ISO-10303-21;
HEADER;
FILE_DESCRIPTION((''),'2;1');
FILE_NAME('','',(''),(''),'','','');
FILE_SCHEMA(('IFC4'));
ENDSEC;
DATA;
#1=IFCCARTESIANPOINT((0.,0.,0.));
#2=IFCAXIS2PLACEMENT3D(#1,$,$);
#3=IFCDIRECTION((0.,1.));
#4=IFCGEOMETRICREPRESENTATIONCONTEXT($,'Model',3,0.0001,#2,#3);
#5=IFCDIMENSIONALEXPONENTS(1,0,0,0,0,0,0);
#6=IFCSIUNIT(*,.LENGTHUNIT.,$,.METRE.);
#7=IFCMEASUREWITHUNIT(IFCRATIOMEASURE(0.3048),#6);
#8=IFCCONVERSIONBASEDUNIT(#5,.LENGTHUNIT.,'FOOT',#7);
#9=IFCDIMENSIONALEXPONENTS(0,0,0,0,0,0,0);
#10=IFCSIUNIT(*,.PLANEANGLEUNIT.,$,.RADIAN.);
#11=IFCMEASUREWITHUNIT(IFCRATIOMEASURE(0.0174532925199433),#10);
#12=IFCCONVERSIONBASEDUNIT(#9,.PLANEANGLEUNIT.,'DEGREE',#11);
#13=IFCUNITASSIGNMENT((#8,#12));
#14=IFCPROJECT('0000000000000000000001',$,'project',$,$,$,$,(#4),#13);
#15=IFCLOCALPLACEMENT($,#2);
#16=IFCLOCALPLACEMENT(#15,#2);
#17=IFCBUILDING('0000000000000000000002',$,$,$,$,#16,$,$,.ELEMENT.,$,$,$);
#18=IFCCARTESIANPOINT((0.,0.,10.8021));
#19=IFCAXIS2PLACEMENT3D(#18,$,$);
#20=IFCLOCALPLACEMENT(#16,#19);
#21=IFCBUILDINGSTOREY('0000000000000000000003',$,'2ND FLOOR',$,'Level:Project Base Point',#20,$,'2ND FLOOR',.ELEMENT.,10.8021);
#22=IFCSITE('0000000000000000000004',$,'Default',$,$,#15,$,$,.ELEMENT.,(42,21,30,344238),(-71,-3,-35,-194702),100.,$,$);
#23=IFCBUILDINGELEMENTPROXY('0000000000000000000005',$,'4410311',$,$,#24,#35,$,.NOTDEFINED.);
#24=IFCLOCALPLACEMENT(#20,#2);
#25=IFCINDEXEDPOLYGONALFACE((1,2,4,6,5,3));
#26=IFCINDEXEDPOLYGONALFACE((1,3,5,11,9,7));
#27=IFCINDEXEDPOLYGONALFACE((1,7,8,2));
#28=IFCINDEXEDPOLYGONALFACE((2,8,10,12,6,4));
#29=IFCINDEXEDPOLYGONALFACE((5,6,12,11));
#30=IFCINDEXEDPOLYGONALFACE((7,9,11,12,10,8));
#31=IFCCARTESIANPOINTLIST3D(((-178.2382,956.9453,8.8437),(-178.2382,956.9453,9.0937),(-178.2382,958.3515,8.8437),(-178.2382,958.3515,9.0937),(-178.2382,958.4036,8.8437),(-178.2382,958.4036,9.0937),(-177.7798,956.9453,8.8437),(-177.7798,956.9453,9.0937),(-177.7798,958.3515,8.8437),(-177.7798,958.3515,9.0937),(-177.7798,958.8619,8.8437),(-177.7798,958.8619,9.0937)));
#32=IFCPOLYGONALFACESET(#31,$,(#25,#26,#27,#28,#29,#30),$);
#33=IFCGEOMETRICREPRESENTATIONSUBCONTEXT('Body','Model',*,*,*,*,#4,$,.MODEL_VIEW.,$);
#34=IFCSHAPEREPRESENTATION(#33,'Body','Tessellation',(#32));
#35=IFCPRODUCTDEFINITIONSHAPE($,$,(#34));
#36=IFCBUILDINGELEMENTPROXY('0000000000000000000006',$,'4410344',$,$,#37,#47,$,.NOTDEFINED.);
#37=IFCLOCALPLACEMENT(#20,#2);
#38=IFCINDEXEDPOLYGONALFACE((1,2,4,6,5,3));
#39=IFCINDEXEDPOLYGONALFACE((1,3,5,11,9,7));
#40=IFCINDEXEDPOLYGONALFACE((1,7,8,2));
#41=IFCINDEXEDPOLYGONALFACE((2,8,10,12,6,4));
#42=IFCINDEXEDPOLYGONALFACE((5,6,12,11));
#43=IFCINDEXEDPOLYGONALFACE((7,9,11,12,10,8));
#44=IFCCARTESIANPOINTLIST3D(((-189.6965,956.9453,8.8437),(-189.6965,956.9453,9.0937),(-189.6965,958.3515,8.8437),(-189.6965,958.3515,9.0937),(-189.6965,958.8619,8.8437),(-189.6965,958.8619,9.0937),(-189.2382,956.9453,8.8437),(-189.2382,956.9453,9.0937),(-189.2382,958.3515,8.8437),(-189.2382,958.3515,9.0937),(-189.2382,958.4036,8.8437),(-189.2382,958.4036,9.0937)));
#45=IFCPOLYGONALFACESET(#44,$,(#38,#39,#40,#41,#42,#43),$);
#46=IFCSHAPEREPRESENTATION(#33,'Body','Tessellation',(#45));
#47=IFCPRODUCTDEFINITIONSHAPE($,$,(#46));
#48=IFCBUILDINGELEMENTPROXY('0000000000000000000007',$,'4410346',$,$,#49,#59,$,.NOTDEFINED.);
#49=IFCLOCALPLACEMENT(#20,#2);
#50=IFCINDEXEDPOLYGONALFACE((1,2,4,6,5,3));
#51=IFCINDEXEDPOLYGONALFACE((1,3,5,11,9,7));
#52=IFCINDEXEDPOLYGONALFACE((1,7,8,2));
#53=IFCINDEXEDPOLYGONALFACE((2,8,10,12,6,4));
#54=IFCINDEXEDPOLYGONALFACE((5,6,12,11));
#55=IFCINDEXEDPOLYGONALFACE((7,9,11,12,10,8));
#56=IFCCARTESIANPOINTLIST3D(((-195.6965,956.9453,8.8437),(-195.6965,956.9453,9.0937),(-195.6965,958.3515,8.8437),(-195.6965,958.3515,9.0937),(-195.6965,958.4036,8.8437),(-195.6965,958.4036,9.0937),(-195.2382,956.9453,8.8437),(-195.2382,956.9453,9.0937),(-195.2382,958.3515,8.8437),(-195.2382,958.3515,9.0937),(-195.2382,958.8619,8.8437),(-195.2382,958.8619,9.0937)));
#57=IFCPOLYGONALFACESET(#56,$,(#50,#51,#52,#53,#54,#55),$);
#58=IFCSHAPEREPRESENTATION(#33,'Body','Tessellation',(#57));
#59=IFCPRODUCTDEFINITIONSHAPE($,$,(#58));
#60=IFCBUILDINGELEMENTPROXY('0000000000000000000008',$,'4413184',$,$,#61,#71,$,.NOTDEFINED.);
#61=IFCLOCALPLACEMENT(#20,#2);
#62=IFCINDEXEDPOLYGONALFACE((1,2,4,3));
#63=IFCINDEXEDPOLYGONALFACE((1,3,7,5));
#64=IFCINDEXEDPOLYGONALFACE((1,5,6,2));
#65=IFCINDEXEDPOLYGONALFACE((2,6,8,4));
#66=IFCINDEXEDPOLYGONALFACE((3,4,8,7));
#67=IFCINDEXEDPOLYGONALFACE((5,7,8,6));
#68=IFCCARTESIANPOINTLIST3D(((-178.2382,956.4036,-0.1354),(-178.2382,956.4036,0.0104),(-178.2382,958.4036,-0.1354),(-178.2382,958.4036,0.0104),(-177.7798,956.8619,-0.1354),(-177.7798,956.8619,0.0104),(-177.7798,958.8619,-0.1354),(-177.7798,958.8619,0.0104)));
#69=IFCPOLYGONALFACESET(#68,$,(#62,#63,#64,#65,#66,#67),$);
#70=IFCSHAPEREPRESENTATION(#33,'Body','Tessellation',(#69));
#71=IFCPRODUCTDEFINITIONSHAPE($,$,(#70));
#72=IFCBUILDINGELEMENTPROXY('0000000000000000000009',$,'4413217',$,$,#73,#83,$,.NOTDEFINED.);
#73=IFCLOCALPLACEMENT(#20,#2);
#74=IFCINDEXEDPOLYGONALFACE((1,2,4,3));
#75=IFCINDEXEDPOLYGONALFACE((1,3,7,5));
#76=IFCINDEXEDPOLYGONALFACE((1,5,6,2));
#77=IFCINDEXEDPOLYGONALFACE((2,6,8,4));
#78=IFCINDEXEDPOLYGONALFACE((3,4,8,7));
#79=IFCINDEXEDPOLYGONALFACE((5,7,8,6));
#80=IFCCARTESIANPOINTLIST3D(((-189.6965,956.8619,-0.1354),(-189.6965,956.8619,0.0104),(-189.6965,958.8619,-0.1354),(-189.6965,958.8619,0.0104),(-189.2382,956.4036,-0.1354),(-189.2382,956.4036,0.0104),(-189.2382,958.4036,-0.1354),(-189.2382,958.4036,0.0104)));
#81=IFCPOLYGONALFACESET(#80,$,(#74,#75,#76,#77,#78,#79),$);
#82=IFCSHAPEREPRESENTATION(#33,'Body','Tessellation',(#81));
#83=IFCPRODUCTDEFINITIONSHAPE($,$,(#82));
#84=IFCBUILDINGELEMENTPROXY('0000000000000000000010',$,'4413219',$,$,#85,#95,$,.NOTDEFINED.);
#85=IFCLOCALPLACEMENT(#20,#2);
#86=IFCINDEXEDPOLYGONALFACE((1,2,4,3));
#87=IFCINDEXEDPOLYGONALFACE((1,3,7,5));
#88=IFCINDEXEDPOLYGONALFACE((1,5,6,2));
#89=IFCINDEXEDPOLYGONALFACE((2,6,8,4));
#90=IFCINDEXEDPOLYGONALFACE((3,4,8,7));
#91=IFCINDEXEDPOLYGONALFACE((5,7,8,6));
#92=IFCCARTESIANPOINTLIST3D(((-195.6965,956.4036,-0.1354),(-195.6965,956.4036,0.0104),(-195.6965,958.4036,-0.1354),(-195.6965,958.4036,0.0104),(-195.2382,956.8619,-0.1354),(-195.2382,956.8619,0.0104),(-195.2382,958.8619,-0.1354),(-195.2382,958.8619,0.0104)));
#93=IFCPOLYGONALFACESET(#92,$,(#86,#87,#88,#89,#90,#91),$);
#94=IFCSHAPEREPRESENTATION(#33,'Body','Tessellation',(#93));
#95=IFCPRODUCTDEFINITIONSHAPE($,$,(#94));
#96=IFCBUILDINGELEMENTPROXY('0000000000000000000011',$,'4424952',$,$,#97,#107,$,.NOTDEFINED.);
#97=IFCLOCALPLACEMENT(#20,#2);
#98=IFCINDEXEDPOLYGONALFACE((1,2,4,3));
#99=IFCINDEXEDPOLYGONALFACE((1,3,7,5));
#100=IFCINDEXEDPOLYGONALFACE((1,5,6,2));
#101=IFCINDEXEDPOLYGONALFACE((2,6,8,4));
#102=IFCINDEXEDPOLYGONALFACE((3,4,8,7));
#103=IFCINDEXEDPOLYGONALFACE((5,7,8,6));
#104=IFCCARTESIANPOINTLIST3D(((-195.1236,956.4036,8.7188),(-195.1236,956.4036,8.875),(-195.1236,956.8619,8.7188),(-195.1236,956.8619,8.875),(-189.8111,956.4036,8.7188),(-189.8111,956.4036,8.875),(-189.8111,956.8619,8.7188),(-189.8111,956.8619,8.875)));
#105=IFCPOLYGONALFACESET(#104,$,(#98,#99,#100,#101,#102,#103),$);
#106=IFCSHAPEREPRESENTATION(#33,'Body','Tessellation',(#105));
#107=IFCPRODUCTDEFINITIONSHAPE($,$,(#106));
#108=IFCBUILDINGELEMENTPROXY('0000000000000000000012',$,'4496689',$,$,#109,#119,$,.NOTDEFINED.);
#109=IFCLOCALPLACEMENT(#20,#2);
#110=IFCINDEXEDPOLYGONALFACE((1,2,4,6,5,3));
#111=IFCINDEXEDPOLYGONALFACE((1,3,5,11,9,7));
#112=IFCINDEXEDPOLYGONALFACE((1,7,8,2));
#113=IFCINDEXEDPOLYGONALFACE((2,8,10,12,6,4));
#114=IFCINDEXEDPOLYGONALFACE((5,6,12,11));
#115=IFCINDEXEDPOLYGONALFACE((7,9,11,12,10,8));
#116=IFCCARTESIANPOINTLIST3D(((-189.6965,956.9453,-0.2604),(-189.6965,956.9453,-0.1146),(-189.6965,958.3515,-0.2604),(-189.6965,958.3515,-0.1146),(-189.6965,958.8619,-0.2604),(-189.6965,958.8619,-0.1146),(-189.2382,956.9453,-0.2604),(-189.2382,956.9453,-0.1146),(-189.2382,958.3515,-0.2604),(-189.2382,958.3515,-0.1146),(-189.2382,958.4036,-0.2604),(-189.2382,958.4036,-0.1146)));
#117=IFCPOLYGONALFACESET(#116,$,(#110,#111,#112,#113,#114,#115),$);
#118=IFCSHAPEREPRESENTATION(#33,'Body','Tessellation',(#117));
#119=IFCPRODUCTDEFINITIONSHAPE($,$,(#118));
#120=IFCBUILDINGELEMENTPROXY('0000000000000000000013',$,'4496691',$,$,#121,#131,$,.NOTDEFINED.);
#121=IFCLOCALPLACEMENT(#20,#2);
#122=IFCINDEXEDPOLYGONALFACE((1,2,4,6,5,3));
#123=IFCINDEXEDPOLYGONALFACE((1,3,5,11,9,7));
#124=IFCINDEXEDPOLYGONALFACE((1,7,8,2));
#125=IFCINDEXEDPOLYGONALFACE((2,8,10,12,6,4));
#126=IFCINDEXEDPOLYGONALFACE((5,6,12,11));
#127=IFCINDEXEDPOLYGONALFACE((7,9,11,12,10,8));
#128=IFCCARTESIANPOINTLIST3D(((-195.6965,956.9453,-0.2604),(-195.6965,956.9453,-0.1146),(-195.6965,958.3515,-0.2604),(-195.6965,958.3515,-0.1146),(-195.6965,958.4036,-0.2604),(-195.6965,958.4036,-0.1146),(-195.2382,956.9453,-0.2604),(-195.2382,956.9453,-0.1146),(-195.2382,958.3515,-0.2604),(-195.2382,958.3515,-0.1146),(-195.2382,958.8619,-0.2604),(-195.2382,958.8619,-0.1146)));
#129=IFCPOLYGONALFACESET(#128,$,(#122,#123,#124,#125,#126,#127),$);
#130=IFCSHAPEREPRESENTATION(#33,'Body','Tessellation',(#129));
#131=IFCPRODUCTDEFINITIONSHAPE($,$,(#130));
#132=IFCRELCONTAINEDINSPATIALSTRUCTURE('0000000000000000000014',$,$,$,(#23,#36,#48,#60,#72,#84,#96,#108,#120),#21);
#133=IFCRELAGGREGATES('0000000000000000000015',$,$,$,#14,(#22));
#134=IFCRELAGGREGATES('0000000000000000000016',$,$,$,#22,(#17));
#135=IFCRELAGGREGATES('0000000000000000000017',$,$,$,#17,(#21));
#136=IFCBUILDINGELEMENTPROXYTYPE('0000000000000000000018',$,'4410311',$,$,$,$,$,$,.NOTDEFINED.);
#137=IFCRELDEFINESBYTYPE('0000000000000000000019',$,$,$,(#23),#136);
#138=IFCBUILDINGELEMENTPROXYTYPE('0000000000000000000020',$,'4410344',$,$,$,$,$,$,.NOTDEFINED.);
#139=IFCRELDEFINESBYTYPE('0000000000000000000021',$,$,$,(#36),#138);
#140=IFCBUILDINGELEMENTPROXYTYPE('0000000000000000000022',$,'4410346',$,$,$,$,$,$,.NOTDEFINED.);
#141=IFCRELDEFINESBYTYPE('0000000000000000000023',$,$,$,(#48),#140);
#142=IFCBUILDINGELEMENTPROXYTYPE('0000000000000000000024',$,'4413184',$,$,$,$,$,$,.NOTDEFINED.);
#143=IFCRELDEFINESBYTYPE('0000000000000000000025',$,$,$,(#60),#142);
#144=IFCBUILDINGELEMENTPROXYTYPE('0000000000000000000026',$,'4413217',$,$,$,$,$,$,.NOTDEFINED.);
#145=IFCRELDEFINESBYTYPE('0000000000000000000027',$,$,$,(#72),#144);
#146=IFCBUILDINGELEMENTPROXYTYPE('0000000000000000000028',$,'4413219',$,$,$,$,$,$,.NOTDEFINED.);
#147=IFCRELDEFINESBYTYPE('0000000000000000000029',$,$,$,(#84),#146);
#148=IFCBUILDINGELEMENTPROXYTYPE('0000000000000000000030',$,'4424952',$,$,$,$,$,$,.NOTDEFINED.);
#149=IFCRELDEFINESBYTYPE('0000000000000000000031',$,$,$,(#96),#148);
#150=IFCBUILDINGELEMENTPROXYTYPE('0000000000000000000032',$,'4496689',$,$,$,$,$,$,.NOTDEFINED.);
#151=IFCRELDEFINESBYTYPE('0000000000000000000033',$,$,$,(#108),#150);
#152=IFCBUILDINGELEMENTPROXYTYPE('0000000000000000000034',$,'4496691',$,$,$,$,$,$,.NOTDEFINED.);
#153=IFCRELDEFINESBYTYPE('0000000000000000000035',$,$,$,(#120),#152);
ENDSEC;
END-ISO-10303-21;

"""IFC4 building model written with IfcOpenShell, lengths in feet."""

from ifc_helpers import new_model, entity, si_unit, converted_unit, direction, frame, frame_2d, origin, place, context, subcontext, project, spatial, polyline, rectangle, outline, extrude, type_object, element, save


model = new_model("IFC4")

# Units and contexts
model_context = context("Model", 3, precision=0.0001, world=origin(), true_north=direction((0.0, 1.0)))
body_context = subcontext(model_context, "Body", "Model", "MODEL_VIEW")
ifc_project = project(units=[converted_unit("LENGTHUNIT", "FOOT", entity("IfcRatioMeasure", 0.3048), si_unit("LENGTHUNIT", "METRE"), dimensions=[1, 0, 0, 0, 0, 0, 0]), converted_unit("PLANEANGLEUNIT", "DEGREE", entity("IfcRatioMeasure", 0.0174532925199433), si_unit("PLANEANGLEUNIT", "RADIAN"), dimensions=[0, 0, 0, 0, 0, 0, 0])], contexts=[model_context])

# Site, building, storey
site_placement = place(None, origin())
site = spatial("IfcSite", under=ifc_project, at=site_placement, Name="Default", CompositionType="ELEMENT", RefLatitude=(42, 21, 30, 344238), RefLongitude=(-71, -3, -35, -194702), RefElevation=100.0)
building_placement = place(site_placement, origin())
building = spatial("IfcBuilding", under=site, at=building_placement, CompositionType="ELEMENT")
storey_placement = place(building_placement, frame((0.0, 0.0, 10.8021)))
storey = spatial("IfcBuildingStorey", under=building, at=storey_placement, Name="2ND FLOOR", ObjectType="Level:Project Base Point", LongName="2ND FLOOR", CompositionType="ELEMENT", Elevation=10.8021)

# Building element proxies
building_element_proxy_type_1 = type_object("IfcBuildingElementProxyType", Name="4410311", PredefinedType="NOTDEFINED")
proxy_1_placement = place(storey_placement, frame((-178.2382, 956.9453, 8.8437)))
element("IfcBuildingElementProxy", 1, at=proxy_1_placement, inside=storey, type_object=building_element_proxy_type_1, Name="4410311", PredefinedType="NOTDEFINED", context=body_context, shape_type="SweptSolid", body=[
    extrude(outline(polyline([(-0.4271, -0.2292), (-0.375, -0.2292), (1.0313, -0.2292), (1.0313, 0.2292), (-0.375, 0.2292), (-0.8854, 0.2292), (-0.4271, -0.2292)])), frame((0.2292, 1.0313, 0.0), z_axis=(0.0, 0.0, 1.0), x_axis=(0.0, -1.0, 0.0)), (0.0, 0.0, 1.0), 0.25),
])
building_element_proxy_type_2 = type_object("IfcBuildingElementProxyType", Name="4410344", PredefinedType="NOTDEFINED")
proxy_2_placement = place(storey_placement, frame((-189.6965, 956.9453, 8.8437)))
element("IfcBuildingElementProxy", 2, at=proxy_2_placement, inside=storey, type_object=building_element_proxy_type_2, Name="4410344", PredefinedType="NOTDEFINED", context=body_context, shape_type="SweptSolid", body=[
    extrude(outline(polyline([(-0.8854, -0.2292), (-0.375, -0.2292), (1.0313, -0.2292), (1.0313, 0.2292), (-0.375, 0.2292), (-0.4271, 0.2292), (-0.8854, -0.2292)])), frame((0.2292, 1.0313, 0.0), z_axis=(0.0, 0.0, 1.0), x_axis=(0.0, -1.0, 0.0)), (0.0, 0.0, 1.0), 0.25),
])
building_element_proxy_type_3 = type_object("IfcBuildingElementProxyType", Name="4410346", PredefinedType="NOTDEFINED")
proxy_3_placement = place(storey_placement, frame((-195.6965, 956.9453, 8.8437)))
element("IfcBuildingElementProxy", 3, at=proxy_3_placement, inside=storey, type_object=building_element_proxy_type_3, Name="4410346", PredefinedType="NOTDEFINED", context=body_context, shape_type="SweptSolid", body=[
    extrude(outline(polyline([(-0.4271, -0.2292), (-0.375, -0.2292), (1.0312, -0.2292), (1.0312, 0.2292), (-0.375, 0.2292), (-0.8854, 0.2292), (-0.4271, -0.2292)])), frame((0.2292, 1.0312, 0.0), z_axis=(0.0, 0.0, 1.0), x_axis=(0.0, -1.0, 0.0)), (0.0, 0.0, 1.0), 0.25),
])
building_element_proxy_type_4 = type_object("IfcBuildingElementProxyType", Name="4413184", PredefinedType="NOTDEFINED")
proxy_4_placement = place(storey_placement, frame((-178.2382, 956.4036, -0.1354)))
element("IfcBuildingElementProxy", 4, at=proxy_4_placement, inside=storey, type_object=building_element_proxy_type_4, Name="4413184", PredefinedType="NOTDEFINED", context=body_context, shape_type="SweptSolid", body=[
    extrude(outline(polyline([(-0.7708, -0.2292), (1.2292, -0.2292), (0.7708, 0.2292), (-1.2292, 0.2292), (-0.7708, -0.2292)])), frame((0.2292, 1.2292, 0.0), z_axis=(0.0, 0.0, 1.0), x_axis=(0.0, -1.0, 0.0)), (0.0, 0.0, 1.0), 0.1458),
])
building_element_proxy_type_5 = type_object("IfcBuildingElementProxyType", Name="4413217", PredefinedType="NOTDEFINED")
proxy_5_placement = place(storey_placement, frame((-189.6965, 956.4036, -0.1354)))
element("IfcBuildingElementProxy", 5, at=proxy_5_placement, inside=storey, type_object=building_element_proxy_type_5, Name="4413217", PredefinedType="NOTDEFINED", context=body_context, shape_type="SweptSolid", body=[
    extrude(outline(polyline([(-1.2292, -0.2292), (0.7708, -0.2292), (1.2292, 0.2292), (-0.7708, 0.2292), (-1.2292, -0.2292)])), frame((0.2292, 1.2292, 0.0), z_axis=(0.0, 0.0, 1.0), x_axis=(0.0, -1.0, 0.0)), (0.0, 0.0, 1.0), 0.1458),
])
building_element_proxy_type_6 = type_object("IfcBuildingElementProxyType", Name="4413219", PredefinedType="NOTDEFINED")
proxy_6_placement = place(storey_placement, frame((-195.6965, 956.4036, -0.1354)))
element("IfcBuildingElementProxy", 6, at=proxy_6_placement, inside=storey, type_object=building_element_proxy_type_6, Name="4413219", PredefinedType="NOTDEFINED", context=body_context, shape_type="SweptSolid", body=[
    extrude(outline(polyline([(-0.7708, -0.2292), (1.2292, -0.2292), (0.7708, 0.2292), (-1.2292, 0.2292), (-0.7708, -0.2292)])), frame((0.2292, 1.2292, 0.0), z_axis=(0.0, 0.0, 1.0), x_axis=(0.0, -1.0, 0.0)), (0.0, 0.0, 1.0), 0.1458),
])
building_element_proxy_type_7 = type_object("IfcBuildingElementProxyType", Name="4424952", PredefinedType="NOTDEFINED")
proxy_7_placement = place(storey_placement, frame((-195.1236, 956.4036, 8.7188)))
element("IfcBuildingElementProxy", 7, at=proxy_7_placement, inside=storey, type_object=building_element_proxy_type_7, Name="4424952", PredefinedType="NOTDEFINED", context=body_context, shape_type="SweptSolid", body=[
    extrude(rectangle(XDim=5.3125, YDim=0.4583, at=frame_2d((0.0, 0.0), x_axis=(1.0, 0.0))), frame((2.6563, 0.2292, 0.0)), (0.0, 0.0, 1.0), 0.1562),
])
building_element_proxy_type_8 = type_object("IfcBuildingElementProxyType", Name="4496689", PredefinedType="NOTDEFINED")
proxy_8_placement = place(storey_placement, frame((-189.6965, 956.9453, -0.2604)))
element("IfcBuildingElementProxy", 8, at=proxy_8_placement, inside=storey, type_object=building_element_proxy_type_8, Name="4496689", PredefinedType="NOTDEFINED", context=body_context, shape_type="SweptSolid", body=[
    extrude(outline(polyline([(-0.8854, -0.2292), (-0.375, -0.2292), (1.0313, -0.2292), (1.0313, 0.2292), (-0.375, 0.2292), (-0.4271, 0.2292), (-0.8854, -0.2292)])), frame((0.2292, 1.0313, 0.0), z_axis=(0.0, 0.0, 1.0), x_axis=(0.0, -1.0, 0.0)), (0.0, 0.0, 1.0), 0.1458),
])
building_element_proxy_type_9 = type_object("IfcBuildingElementProxyType", Name="4496691", PredefinedType="NOTDEFINED")
proxy_9_placement = place(storey_placement, frame((-195.6965, 956.9453, -0.2604)))
element("IfcBuildingElementProxy", 9, at=proxy_9_placement, inside=storey, type_object=building_element_proxy_type_9, Name="4496691", PredefinedType="NOTDEFINED", context=body_context, shape_type="SweptSolid", body=[
    extrude(outline(polyline([(-0.4271, -0.2292), (-0.375, -0.2292), (1.0312, -0.2292), (1.0312, 0.2292), (-0.375, 0.2292), (-0.8854, 0.2292), (-0.4271, -0.2292)])), frame((0.2292, 1.0312, 0.0), z_axis=(0.0, 0.0, 1.0), x_axis=(0.0, -1.0, 0.0)), (0.0, 0.0, 1.0), 0.1458),
])

save(model, "model.ifc")
